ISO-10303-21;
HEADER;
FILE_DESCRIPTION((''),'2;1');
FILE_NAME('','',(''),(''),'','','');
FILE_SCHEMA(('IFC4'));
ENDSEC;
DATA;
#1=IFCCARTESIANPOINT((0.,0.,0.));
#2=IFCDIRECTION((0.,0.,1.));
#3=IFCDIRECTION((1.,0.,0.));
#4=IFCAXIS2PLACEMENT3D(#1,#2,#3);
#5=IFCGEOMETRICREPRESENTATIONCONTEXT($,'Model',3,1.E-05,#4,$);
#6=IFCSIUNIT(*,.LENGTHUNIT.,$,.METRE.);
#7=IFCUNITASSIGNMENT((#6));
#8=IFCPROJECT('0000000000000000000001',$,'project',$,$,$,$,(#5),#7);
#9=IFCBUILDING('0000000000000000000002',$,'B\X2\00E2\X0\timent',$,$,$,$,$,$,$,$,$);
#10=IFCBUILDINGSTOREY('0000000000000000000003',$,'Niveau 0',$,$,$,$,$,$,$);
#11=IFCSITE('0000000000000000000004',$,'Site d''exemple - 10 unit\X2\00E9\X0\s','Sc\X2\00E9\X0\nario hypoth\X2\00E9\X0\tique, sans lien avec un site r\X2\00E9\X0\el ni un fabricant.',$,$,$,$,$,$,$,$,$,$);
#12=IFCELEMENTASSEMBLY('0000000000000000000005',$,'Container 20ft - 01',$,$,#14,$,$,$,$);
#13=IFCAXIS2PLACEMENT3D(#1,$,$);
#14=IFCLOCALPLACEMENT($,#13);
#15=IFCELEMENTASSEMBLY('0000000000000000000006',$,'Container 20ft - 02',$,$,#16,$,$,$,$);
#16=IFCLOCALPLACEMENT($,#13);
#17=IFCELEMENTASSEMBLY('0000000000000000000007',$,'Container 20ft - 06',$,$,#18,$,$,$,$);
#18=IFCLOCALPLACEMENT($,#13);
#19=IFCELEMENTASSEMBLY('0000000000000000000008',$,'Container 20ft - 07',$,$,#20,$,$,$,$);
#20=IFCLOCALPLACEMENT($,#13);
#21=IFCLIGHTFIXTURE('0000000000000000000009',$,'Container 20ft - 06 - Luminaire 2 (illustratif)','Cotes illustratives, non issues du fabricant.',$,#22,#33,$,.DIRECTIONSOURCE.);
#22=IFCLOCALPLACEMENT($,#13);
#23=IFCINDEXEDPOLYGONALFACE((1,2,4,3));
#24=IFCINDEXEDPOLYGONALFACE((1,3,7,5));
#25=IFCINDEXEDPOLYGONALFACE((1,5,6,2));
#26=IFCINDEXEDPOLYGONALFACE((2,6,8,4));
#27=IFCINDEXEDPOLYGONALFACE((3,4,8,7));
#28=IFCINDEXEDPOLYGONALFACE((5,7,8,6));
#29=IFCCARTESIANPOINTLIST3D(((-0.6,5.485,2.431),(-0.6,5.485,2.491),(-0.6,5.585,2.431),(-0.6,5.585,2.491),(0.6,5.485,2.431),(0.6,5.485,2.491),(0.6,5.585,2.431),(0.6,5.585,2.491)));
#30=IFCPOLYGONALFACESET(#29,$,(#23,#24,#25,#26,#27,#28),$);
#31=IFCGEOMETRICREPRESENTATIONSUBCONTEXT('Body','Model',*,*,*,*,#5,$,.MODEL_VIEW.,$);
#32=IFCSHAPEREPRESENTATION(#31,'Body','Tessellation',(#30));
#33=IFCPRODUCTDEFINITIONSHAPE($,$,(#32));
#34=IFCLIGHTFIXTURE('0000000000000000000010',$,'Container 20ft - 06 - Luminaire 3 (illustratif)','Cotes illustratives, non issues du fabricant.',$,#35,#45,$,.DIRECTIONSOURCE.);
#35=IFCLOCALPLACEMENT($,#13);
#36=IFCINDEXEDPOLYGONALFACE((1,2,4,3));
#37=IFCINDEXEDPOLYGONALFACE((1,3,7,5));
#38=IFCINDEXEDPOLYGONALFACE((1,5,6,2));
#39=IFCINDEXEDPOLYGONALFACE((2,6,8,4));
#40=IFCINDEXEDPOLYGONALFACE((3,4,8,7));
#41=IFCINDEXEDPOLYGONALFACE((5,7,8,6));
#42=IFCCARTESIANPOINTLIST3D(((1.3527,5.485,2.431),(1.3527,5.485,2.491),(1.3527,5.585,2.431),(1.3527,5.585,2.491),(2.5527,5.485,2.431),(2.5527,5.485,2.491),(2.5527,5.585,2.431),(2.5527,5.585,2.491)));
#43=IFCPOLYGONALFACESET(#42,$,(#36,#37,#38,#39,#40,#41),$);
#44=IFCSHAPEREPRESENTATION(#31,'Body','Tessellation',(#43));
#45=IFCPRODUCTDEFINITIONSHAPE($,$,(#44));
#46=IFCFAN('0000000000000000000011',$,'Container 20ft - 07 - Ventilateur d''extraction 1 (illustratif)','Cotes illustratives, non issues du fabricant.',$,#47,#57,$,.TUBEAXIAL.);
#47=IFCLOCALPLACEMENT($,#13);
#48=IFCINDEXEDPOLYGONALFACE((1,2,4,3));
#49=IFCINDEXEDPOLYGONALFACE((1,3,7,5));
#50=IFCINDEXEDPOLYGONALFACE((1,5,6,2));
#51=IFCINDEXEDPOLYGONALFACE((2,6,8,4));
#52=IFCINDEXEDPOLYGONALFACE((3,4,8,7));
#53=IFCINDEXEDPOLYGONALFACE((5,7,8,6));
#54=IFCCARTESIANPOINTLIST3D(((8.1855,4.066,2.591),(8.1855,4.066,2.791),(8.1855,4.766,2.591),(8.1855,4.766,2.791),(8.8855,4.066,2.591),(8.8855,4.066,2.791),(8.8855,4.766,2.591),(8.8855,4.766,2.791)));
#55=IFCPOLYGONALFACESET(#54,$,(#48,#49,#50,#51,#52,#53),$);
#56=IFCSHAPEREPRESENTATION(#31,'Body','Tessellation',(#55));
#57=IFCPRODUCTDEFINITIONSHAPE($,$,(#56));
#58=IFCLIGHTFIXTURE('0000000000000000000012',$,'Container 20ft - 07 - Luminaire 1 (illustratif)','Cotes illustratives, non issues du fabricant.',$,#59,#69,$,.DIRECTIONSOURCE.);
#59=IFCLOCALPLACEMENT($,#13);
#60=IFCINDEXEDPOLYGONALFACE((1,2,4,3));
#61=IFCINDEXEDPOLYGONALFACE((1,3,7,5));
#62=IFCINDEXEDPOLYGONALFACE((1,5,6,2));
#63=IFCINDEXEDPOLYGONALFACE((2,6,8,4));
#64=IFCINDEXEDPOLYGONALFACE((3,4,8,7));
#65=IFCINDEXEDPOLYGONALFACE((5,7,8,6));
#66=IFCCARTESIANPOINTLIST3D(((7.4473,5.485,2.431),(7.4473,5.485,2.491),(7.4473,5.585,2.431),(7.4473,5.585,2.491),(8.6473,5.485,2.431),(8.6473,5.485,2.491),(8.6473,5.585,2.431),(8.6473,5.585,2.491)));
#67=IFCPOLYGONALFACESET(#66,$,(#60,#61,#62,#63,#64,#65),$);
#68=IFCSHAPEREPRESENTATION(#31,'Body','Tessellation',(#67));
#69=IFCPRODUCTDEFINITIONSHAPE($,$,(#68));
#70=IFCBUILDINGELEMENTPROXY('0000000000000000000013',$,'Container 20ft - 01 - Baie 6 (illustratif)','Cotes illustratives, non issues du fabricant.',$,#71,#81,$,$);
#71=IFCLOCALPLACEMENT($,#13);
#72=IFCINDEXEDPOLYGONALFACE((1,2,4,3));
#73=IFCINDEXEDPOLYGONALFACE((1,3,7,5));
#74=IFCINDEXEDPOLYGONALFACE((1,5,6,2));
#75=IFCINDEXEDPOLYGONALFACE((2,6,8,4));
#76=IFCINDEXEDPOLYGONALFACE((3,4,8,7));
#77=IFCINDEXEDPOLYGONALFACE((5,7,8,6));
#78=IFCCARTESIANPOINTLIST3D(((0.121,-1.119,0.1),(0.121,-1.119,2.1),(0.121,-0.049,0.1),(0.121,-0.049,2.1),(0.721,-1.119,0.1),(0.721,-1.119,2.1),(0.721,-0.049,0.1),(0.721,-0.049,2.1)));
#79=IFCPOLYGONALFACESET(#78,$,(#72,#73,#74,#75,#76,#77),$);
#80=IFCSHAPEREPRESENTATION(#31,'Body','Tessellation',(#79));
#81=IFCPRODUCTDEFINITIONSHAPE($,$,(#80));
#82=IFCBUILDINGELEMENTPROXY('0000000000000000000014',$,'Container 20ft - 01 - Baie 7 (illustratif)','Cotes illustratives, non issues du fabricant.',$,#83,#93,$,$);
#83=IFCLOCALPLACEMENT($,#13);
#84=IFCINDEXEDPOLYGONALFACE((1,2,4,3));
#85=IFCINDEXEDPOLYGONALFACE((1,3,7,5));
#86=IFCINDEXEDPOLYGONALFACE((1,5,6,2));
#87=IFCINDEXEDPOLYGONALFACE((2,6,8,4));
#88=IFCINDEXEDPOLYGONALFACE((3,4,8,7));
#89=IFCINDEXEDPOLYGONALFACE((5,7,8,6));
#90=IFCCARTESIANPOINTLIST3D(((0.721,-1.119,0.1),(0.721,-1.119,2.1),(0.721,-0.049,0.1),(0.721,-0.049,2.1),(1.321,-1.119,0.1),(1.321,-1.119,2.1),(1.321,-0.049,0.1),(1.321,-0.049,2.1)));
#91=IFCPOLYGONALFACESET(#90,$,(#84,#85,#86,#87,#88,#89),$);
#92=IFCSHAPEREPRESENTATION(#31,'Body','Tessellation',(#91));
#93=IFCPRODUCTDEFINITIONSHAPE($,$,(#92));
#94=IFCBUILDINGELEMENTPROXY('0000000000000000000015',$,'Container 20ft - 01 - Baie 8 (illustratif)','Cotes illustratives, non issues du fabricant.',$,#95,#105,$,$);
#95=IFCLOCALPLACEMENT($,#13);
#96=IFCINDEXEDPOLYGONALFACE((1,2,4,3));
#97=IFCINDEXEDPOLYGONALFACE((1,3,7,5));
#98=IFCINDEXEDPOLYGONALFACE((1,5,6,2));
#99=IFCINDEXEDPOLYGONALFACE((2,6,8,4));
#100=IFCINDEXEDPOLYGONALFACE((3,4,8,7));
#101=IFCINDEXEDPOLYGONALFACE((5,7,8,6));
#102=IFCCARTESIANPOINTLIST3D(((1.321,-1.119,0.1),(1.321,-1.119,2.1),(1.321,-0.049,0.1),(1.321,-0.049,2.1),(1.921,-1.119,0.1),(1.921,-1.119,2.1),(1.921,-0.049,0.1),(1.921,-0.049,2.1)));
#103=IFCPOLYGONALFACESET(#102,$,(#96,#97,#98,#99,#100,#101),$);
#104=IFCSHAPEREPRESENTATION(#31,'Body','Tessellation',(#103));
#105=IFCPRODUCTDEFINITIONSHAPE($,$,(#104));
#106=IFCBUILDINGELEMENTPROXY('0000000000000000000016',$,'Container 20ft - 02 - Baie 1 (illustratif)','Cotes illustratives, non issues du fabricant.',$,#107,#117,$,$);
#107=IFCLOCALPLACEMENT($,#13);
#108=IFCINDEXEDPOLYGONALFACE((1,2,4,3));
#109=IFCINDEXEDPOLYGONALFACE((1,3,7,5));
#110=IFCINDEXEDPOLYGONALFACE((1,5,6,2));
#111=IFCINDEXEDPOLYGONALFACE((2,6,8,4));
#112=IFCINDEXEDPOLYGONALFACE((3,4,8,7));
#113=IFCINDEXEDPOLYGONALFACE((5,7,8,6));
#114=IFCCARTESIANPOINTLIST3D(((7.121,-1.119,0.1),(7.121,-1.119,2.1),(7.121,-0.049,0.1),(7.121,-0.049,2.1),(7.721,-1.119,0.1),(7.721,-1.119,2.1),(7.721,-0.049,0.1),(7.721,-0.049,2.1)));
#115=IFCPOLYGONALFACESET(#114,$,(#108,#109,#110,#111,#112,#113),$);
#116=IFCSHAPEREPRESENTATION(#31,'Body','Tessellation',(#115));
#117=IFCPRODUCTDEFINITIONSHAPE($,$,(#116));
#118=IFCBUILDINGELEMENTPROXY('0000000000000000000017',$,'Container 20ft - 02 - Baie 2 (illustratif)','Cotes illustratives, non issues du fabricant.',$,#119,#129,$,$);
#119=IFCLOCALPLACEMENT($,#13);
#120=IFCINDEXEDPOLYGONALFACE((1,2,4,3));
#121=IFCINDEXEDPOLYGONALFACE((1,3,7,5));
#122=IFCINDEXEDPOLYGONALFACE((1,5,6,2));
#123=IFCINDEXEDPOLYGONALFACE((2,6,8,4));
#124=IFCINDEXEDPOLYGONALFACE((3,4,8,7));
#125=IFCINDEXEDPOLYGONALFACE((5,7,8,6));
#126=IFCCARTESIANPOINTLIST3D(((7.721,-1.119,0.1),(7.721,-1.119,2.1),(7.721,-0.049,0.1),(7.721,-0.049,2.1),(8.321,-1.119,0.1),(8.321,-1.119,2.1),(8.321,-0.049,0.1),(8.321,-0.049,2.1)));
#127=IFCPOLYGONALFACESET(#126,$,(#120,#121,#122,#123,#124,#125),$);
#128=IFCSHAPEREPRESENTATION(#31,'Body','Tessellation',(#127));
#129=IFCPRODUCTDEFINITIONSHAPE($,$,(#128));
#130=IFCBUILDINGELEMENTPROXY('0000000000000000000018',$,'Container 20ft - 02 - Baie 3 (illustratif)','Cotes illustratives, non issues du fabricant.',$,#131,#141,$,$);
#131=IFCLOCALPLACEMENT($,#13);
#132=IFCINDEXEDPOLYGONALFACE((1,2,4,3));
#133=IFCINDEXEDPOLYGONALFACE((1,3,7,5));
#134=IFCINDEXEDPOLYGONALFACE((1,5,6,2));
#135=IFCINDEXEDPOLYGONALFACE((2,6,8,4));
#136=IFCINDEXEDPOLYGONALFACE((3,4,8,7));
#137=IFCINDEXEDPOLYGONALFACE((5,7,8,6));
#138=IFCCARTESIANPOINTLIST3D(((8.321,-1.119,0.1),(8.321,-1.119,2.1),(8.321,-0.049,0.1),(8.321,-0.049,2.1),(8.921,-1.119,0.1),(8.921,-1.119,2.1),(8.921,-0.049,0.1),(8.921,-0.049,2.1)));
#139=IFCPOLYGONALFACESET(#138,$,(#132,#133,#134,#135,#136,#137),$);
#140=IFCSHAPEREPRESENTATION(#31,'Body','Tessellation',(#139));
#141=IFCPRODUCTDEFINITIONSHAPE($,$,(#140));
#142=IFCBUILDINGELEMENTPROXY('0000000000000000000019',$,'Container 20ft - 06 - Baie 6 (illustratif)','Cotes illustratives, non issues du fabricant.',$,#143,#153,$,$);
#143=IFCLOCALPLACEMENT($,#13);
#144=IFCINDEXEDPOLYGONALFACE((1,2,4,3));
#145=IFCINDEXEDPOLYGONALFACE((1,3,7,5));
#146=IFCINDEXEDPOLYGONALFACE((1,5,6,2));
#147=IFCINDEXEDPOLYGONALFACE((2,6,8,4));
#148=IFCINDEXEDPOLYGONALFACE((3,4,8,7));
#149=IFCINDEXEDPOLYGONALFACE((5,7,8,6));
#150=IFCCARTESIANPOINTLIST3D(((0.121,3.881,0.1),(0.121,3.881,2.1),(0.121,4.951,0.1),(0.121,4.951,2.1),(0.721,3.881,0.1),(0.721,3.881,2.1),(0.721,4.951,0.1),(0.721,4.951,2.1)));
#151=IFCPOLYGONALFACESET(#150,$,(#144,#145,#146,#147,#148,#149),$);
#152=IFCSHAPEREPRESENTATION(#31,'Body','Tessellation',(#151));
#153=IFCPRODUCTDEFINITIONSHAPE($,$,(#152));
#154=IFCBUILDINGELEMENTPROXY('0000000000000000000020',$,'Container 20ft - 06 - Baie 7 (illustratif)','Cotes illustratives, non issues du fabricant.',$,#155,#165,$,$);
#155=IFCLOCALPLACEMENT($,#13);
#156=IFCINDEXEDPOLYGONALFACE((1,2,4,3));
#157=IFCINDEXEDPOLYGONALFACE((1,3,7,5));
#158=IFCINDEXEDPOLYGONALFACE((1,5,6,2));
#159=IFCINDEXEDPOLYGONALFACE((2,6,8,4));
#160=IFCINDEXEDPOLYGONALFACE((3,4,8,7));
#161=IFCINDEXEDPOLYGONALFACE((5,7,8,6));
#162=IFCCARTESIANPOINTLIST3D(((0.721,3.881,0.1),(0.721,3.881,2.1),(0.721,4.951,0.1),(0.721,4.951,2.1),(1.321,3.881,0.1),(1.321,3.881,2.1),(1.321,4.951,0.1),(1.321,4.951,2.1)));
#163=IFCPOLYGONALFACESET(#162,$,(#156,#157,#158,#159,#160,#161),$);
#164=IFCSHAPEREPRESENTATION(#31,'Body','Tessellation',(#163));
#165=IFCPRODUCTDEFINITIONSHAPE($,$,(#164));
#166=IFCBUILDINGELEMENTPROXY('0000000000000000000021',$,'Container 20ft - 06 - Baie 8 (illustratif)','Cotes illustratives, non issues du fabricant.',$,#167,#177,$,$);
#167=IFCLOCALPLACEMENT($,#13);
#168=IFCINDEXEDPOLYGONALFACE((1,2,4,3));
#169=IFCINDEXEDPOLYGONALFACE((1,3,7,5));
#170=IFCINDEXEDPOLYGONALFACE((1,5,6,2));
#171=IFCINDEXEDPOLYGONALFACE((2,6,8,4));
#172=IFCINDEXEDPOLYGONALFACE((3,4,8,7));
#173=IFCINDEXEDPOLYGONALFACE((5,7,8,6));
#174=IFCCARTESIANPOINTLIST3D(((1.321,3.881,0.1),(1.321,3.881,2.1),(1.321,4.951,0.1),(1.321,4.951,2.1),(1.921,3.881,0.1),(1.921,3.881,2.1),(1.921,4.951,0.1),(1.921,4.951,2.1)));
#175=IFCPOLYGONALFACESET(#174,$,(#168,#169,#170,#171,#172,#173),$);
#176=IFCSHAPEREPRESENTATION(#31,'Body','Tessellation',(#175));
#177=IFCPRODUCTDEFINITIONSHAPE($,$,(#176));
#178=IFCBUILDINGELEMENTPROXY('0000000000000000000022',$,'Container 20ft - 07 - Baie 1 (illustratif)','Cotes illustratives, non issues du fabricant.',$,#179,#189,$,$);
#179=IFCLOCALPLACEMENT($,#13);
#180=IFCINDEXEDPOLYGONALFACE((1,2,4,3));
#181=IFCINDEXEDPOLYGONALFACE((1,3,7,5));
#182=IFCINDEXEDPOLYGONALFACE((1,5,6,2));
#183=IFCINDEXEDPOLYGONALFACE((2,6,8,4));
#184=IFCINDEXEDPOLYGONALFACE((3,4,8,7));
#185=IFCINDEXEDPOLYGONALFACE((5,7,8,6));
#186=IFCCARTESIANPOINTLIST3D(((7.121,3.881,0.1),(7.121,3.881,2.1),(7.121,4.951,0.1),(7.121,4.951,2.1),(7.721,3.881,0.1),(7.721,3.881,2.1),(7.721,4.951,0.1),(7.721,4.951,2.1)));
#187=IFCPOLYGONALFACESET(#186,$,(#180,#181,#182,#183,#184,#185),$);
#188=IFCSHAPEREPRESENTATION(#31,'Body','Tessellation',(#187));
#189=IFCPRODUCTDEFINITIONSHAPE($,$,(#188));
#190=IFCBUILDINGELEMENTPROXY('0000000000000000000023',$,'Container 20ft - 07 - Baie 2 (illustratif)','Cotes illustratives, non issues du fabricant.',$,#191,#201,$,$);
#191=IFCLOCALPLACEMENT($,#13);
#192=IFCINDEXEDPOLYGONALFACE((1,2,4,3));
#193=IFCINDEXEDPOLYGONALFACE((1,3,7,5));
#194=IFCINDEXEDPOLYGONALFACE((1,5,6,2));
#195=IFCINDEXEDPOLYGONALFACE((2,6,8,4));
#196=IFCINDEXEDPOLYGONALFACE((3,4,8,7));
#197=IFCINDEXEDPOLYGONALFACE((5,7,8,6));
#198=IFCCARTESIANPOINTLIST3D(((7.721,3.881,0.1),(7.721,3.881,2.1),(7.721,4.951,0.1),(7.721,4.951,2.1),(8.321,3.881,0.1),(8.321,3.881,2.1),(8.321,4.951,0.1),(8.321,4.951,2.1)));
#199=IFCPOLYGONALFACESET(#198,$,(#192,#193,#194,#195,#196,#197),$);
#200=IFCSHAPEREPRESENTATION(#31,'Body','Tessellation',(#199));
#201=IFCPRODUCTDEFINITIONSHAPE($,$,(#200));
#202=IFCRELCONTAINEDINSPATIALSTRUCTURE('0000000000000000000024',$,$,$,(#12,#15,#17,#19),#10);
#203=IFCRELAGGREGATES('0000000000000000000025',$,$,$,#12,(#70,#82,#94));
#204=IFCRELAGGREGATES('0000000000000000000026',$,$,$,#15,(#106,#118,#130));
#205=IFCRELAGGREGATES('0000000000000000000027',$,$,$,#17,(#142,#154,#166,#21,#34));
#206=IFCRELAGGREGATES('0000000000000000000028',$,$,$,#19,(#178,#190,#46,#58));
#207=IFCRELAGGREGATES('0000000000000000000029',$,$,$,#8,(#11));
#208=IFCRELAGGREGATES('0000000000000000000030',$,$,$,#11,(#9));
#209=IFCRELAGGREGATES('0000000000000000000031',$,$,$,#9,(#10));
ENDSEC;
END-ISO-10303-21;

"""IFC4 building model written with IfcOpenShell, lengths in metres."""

from ifc_helpers import new_model, si_unit, frame, origin_with_axes, place, context, subcontext, project, spatial, rectangle, extrude, element, aggregate, save


model = new_model("IFC4")

# Units and contexts
model_context = context("Model", 3, precision=1e-05, world=origin_with_axes())
body_context = subcontext(model_context, "Body", "Model", "MODEL_VIEW")
ifc_project = project(units=[si_unit("LENGTHUNIT", "METRE")], contexts=[model_context])

# Site, building, storey
site = spatial("IfcSite", under=ifc_project, Name="Site d'exemple - 10 unités", Description="Scénario hypothétique, sans lien avec un site réel ni un fabricant.")
building = spatial("IfcBuilding", under=site, Name="Bâtiment")
storey = spatial("IfcBuildingStorey", under=building, Name="Niveau 0")

# Element assembly
assembly_1 = element("IfcElementAssembly", 1, inside=storey, Name="Container 20ft - 01")

# Element assembly
assembly_2 = element("IfcElementAssembly", 2, inside=storey, Name="Container 20ft - 02")

# Element assembly
assembly_3 = element("IfcElementAssembly", 3, inside=storey, Name="Container 20ft - 06")

# Element assembly
assembly_4 = element("IfcElementAssembly", 4, inside=storey, Name="Container 20ft - 07")

# Light fixtures
light_fixture_1_placement = place(None, frame((0.0, 5.535, 2.431), z_axis=(0.0, 0.0, 1.0), x_axis=(1.0, 0.0, 0.0)))
light_fixture_1 = element("IfcLightFixture", 5, at=light_fixture_1_placement, Name="Container 20ft - 06 - Luminaire 2 (illustratif)", Description="Cotes illustratives, non issues du fabricant.", PredefinedType="DIRECTIONSOURCE", context=body_context, shape_type="SweptSolid", body=[
    extrude(rectangle(XDim=1.2, YDim=0.1), origin_with_axes(), (0.0, 0.0, 1.0), 0.06),
])
light_fixture_2_placement = place(None, frame((1.9527, 5.535, 2.431), z_axis=(0.0, 0.0, 1.0), x_axis=(1.0, 0.0, 0.0)))
light_fixture_2 = element("IfcLightFixture", 6, at=light_fixture_2_placement, Name="Container 20ft - 06 - Luminaire 3 (illustratif)", Description="Cotes illustratives, non issues du fabricant.", PredefinedType="DIRECTIONSOURCE", context=body_context, shape_type="SweptSolid", body=[
    extrude(rectangle(XDim=1.2, YDim=0.1), origin_with_axes(), (0.0, 0.0, 1.0), 0.06),
])

# Fan
fan_1_placement = place(None, frame((8.5355, 4.416, 2.591), z_axis=(0.0, 0.0, 1.0), x_axis=(1.0, 0.0, 0.0)))
fan_1 = element("IfcFan", 7, at=fan_1_placement, Name="Container 20ft - 07 - Ventilateur d'extraction 1 (illustratif)", Description="Cotes illustratives, non issues du fabricant.", PredefinedType="TUBEAXIAL", context=body_context, shape_type="SweptSolid", body=[
    extrude(rectangle(XDim=0.7, YDim=0.7), origin_with_axes(), (0.0, 0.0, 1.0), 0.2),
])

# Light fixture
light_fixture_3_placement = place(None, frame((8.0473, 5.535, 2.431), z_axis=(0.0, 0.0, 1.0), x_axis=(1.0, 0.0, 0.0)))
light_fixture_3 = element("IfcLightFixture", 8, at=light_fixture_3_placement, Name="Container 20ft - 07 - Luminaire 1 (illustratif)", Description="Cotes illustratives, non issues du fabricant.", PredefinedType="DIRECTIONSOURCE", context=body_context, shape_type="SweptSolid", body=[
    extrude(rectangle(XDim=1.2, YDim=0.1), origin_with_axes(), (0.0, 0.0, 1.0), 0.06),
])

# Building element proxies
proxy_1_placement = place(None, frame((0.421, -0.584, 0.1), z_axis=(0.0, 0.0, 1.0), x_axis=(1.0, 0.0, 0.0)))
proxy_1 = element("IfcBuildingElementProxy", 9, at=proxy_1_placement, Name="Container 20ft - 01 - Baie 6 (illustratif)", Description="Cotes illustratives, non issues du fabricant.", context=body_context, shape_type="SweptSolid", body=[
    extrude(rectangle(XDim=0.6, YDim=1.07), origin_with_axes(), (0.0, 0.0, 1.0), 2.0),
])
proxy_2_placement = place(None, frame((1.021, -0.584, 0.1), z_axis=(0.0, 0.0, 1.0), x_axis=(1.0, 0.0, 0.0)))
proxy_2 = element("IfcBuildingElementProxy", 10, at=proxy_2_placement, Name="Container 20ft - 01 - Baie 7 (illustratif)", Description="Cotes illustratives, non issues du fabricant.", context=body_context, shape_type="SweptSolid", body=[
    extrude(rectangle(XDim=0.6, YDim=1.07), origin_with_axes(), (0.0, 0.0, 1.0), 2.0),
])
proxy_3_placement = place(None, frame((1.621, -0.584, 0.1), z_axis=(0.0, 0.0, 1.0), x_axis=(1.0, 0.0, 0.0)))
proxy_3 = element("IfcBuildingElementProxy", 11, at=proxy_3_placement, Name="Container 20ft - 01 - Baie 8 (illustratif)", Description="Cotes illustratives, non issues du fabricant.", context=body_context, shape_type="SweptSolid", body=[
    extrude(rectangle(XDim=0.6, YDim=1.07), origin_with_axes(), (0.0, 0.0, 1.0), 2.0),
])
aggregate(assembly_1, [proxy_1, proxy_2, proxy_3])
proxy_4_placement = place(None, frame((7.421, -0.584, 0.1), z_axis=(0.0, 0.0, 1.0), x_axis=(1.0, 0.0, 0.0)))
proxy_4 = element("IfcBuildingElementProxy", 12, at=proxy_4_placement, Name="Container 20ft - 02 - Baie 1 (illustratif)", Description="Cotes illustratives, non issues du fabricant.", context=body_context, shape_type="SweptSolid", body=[
    extrude(rectangle(XDim=0.6, YDim=1.07), origin_with_axes(), (0.0, 0.0, 1.0), 2.0),
])
proxy_5_placement = place(None, frame((8.021, -0.584, 0.1), z_axis=(0.0, 0.0, 1.0), x_axis=(1.0, 0.0, 0.0)))
proxy_5 = element("IfcBuildingElementProxy", 13, at=proxy_5_placement, Name="Container 20ft - 02 - Baie 2 (illustratif)", Description="Cotes illustratives, non issues du fabricant.", context=body_context, shape_type="SweptSolid", body=[
    extrude(rectangle(XDim=0.6, YDim=1.07), origin_with_axes(), (0.0, 0.0, 1.0), 2.0),
])
proxy_6_placement = place(None, frame((8.621, -0.584, 0.1), z_axis=(0.0, 0.0, 1.0), x_axis=(1.0, 0.0, 0.0)))
proxy_6 = element("IfcBuildingElementProxy", 14, at=proxy_6_placement, Name="Container 20ft - 02 - Baie 3 (illustratif)", Description="Cotes illustratives, non issues du fabricant.", context=body_context, shape_type="SweptSolid", body=[
    extrude(rectangle(XDim=0.6, YDim=1.07), origin_with_axes(), (0.0, 0.0, 1.0), 2.0),
])
aggregate(assembly_2, [proxy_4, proxy_5, proxy_6])
proxy_7_placement = place(None, frame((0.421, 4.416, 0.1), z_axis=(0.0, 0.0, 1.0), x_axis=(1.0, 0.0, 0.0)))
proxy_7 = element("IfcBuildingElementProxy", 15, at=proxy_7_placement, Name="Container 20ft - 06 - Baie 6 (illustratif)", Description="Cotes illustratives, non issues du fabricant.", context=body_context, shape_type="SweptSolid", body=[
    extrude(rectangle(XDim=0.6, YDim=1.07), origin_with_axes(), (0.0, 0.0, 1.0), 2.0),
])
proxy_8_placement = place(None, frame((1.021, 4.416, 0.1), z_axis=(0.0, 0.0, 1.0), x_axis=(1.0, 0.0, 0.0)))
proxy_8 = element("IfcBuildingElementProxy", 16, at=proxy_8_placement, Name="Container 20ft - 06 - Baie 7 (illustratif)", Description="Cotes illustratives, non issues du fabricant.", context=body_context, shape_type="SweptSolid", body=[
    extrude(rectangle(XDim=0.6, YDim=1.07), origin_with_axes(), (0.0, 0.0, 1.0), 2.0),
])
proxy_9_placement = place(None, frame((1.621, 4.416, 0.1), z_axis=(0.0, 0.0, 1.0), x_axis=(1.0, 0.0, 0.0)))
proxy_9 = element("IfcBuildingElementProxy", 17, at=proxy_9_placement, Name="Container 20ft - 06 - Baie 8 (illustratif)", Description="Cotes illustratives, non issues du fabricant.", context=body_context, shape_type="SweptSolid", body=[
    extrude(rectangle(XDim=0.6, YDim=1.07), origin_with_axes(), (0.0, 0.0, 1.0), 2.0),
])
aggregate(assembly_3, [proxy_7, proxy_8, proxy_9, light_fixture_1, light_fixture_2])
proxy_10_placement = place(None, frame((7.421, 4.416, 0.1), z_axis=(0.0, 0.0, 1.0), x_axis=(1.0, 0.0, 0.0)))
proxy_10 = element("IfcBuildingElementProxy", 18, at=proxy_10_placement, Name="Container 20ft - 07 - Baie 1 (illustratif)", Description="Cotes illustratives, non issues du fabricant.", context=body_context, shape_type="SweptSolid", body=[
    extrude(rectangle(XDim=0.6, YDim=1.07), origin_with_axes(), (0.0, 0.0, 1.0), 2.0),
])
proxy_11_placement = place(None, frame((8.021, 4.416, 0.1), z_axis=(0.0, 0.0, 1.0), x_axis=(1.0, 0.0, 0.0)))
proxy_11 = element("IfcBuildingElementProxy", 19, at=proxy_11_placement, Name="Container 20ft - 07 - Baie 2 (illustratif)", Description="Cotes illustratives, non issues du fabricant.", context=body_context, shape_type="SweptSolid", body=[
    extrude(rectangle(XDim=0.6, YDim=1.07), origin_with_axes(), (0.0, 0.0, 1.0), 2.0),
])
aggregate(assembly_4, [proxy_10, proxy_11, fan_1, light_fixture_3])

save(model, "model.ifc")
